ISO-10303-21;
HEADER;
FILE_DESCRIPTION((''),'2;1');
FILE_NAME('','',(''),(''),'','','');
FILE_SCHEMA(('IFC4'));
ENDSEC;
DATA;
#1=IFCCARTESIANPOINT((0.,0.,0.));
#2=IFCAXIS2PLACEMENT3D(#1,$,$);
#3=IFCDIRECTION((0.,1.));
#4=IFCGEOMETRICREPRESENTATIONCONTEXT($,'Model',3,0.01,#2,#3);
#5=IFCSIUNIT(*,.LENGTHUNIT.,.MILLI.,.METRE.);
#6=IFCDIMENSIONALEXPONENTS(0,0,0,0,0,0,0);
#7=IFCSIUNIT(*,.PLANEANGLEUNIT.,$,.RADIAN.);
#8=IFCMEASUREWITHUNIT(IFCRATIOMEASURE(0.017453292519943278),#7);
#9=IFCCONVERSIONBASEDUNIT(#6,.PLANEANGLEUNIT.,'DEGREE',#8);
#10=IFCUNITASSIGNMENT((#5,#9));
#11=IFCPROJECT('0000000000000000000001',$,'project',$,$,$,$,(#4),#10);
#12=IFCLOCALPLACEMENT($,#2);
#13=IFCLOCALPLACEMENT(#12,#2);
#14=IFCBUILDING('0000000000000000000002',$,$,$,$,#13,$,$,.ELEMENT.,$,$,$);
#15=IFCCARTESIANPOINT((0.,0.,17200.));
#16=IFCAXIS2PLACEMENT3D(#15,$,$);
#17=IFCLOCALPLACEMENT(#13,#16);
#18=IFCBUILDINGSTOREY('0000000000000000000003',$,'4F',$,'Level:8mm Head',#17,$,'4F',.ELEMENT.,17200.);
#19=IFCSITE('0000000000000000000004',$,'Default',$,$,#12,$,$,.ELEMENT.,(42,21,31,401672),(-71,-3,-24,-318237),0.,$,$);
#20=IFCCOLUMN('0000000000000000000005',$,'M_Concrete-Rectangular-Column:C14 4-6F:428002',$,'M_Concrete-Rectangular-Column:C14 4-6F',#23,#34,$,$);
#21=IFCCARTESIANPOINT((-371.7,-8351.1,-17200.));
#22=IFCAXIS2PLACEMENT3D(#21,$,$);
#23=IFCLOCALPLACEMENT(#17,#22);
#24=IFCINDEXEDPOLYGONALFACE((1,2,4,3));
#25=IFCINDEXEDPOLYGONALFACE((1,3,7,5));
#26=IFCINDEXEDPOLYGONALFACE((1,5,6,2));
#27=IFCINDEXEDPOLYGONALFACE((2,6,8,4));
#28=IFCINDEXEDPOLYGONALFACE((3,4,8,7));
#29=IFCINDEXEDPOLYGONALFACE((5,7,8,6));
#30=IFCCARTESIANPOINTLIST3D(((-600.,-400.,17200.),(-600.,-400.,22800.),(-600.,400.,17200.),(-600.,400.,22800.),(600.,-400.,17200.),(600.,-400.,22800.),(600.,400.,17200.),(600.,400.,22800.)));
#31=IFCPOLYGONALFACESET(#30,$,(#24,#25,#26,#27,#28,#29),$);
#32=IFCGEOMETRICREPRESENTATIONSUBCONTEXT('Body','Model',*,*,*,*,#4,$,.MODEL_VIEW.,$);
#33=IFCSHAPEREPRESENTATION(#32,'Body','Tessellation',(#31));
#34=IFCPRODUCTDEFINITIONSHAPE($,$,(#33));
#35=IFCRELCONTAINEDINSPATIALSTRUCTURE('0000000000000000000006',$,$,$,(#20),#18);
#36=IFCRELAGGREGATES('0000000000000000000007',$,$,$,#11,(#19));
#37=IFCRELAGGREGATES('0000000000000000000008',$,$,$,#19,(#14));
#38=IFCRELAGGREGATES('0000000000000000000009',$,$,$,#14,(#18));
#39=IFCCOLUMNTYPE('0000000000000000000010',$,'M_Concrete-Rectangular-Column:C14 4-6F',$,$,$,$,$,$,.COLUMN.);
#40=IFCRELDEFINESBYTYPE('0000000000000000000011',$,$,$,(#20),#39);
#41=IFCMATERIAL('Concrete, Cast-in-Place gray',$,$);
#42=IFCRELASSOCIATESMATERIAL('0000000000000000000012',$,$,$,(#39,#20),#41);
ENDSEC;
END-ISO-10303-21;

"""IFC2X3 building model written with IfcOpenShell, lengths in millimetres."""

from ifc_helpers import new_model, entity, si_unit, converted_unit, direction, frame, origin, origin_2d_with_axis, place, context, subcontext, project, spatial, rectangle, extrude, source, transform, mapped, material, type_object, type_shapes, element, save


model = new_model("IFC2X3")

# Units and contexts
model_context = context("Model", 3, precision=0.01, world=origin(), true_north=direction((0.0, 1.0)))
body_context = subcontext(model_context, "Body", "Model", "MODEL_VIEW")
ifc_project = project(units=[si_unit("LENGTHUNIT", "METRE", prefix="MILLI"), converted_unit("PLANEANGLEUNIT", "DEGREE", entity("IfcRatioMeasure", 0.017453292519943278), si_unit("PLANEANGLEUNIT", "RADIAN"), dimensions=[0, 0, 0, 0, 0, 0, 0])], contexts=[model_context])

# Site, building, storey
site_placement = place(None, origin())
site = spatial("IfcSite", under=ifc_project, at=site_placement, Name="Default", CompositionType="ELEMENT", RefLatitude=(42, 21, 31, 401672), RefLongitude=(-71, -3, -24, -318237), RefElevation=0.0)
building_placement = place(site_placement, origin())
building = spatial("IfcBuilding", under=site, at=building_placement, CompositionType="ELEMENT")
storey_placement = place(building_placement, frame((0.0, 0.0, 17200.0)))
storey = spatial("IfcBuildingStorey", under=building, at=storey_placement, Name="4F", ObjectType="Level:8mm Head", LongName="4F", CompositionType="ELEMENT", Elevation=17200.0)

# Column
ifc_material_1 = material(Name="Concrete, Cast-in-Place gray")
column_type = type_object("IfcColumnType", Name="M_Concrete-Rectangular-Column:C14 4-6F", PredefinedType="COLUMN", material=ifc_material_1)
shared_shape = source(origin(), body_context, "Body", "SweptSolid", [
    extrude(rectangle(XDim=800.0, YDim=1200.0, at=origin_2d_with_axis()), frame((0.0, 0.0, 17200.0), z_axis=(0.0, 0.0, 1.0), x_axis=(0.0, -1.0, 0.0)), (0.0, 0.0, 1.0), 5600.0),
])
type_shapes(column_type, [shared_shape])
column_placement = place(storey_placement, frame((-371.7, -8351.1, -17200.0)))
element("IfcColumn", 1, at=column_placement, inside=storey, type_object=column_type, material=ifc_material_1, Name="M_Concrete-Rectangular-Column:C14 4-6F:428002", ObjectType="M_Concrete-Rectangular-Column:C14 4-6F", context=body_context, shape_type="MappedRepresentation", body=[
    mapped(shared_shape, transform((0.0, 0.0, 0.0), scale=1.0)),
])

save(model, "model.ifc")
